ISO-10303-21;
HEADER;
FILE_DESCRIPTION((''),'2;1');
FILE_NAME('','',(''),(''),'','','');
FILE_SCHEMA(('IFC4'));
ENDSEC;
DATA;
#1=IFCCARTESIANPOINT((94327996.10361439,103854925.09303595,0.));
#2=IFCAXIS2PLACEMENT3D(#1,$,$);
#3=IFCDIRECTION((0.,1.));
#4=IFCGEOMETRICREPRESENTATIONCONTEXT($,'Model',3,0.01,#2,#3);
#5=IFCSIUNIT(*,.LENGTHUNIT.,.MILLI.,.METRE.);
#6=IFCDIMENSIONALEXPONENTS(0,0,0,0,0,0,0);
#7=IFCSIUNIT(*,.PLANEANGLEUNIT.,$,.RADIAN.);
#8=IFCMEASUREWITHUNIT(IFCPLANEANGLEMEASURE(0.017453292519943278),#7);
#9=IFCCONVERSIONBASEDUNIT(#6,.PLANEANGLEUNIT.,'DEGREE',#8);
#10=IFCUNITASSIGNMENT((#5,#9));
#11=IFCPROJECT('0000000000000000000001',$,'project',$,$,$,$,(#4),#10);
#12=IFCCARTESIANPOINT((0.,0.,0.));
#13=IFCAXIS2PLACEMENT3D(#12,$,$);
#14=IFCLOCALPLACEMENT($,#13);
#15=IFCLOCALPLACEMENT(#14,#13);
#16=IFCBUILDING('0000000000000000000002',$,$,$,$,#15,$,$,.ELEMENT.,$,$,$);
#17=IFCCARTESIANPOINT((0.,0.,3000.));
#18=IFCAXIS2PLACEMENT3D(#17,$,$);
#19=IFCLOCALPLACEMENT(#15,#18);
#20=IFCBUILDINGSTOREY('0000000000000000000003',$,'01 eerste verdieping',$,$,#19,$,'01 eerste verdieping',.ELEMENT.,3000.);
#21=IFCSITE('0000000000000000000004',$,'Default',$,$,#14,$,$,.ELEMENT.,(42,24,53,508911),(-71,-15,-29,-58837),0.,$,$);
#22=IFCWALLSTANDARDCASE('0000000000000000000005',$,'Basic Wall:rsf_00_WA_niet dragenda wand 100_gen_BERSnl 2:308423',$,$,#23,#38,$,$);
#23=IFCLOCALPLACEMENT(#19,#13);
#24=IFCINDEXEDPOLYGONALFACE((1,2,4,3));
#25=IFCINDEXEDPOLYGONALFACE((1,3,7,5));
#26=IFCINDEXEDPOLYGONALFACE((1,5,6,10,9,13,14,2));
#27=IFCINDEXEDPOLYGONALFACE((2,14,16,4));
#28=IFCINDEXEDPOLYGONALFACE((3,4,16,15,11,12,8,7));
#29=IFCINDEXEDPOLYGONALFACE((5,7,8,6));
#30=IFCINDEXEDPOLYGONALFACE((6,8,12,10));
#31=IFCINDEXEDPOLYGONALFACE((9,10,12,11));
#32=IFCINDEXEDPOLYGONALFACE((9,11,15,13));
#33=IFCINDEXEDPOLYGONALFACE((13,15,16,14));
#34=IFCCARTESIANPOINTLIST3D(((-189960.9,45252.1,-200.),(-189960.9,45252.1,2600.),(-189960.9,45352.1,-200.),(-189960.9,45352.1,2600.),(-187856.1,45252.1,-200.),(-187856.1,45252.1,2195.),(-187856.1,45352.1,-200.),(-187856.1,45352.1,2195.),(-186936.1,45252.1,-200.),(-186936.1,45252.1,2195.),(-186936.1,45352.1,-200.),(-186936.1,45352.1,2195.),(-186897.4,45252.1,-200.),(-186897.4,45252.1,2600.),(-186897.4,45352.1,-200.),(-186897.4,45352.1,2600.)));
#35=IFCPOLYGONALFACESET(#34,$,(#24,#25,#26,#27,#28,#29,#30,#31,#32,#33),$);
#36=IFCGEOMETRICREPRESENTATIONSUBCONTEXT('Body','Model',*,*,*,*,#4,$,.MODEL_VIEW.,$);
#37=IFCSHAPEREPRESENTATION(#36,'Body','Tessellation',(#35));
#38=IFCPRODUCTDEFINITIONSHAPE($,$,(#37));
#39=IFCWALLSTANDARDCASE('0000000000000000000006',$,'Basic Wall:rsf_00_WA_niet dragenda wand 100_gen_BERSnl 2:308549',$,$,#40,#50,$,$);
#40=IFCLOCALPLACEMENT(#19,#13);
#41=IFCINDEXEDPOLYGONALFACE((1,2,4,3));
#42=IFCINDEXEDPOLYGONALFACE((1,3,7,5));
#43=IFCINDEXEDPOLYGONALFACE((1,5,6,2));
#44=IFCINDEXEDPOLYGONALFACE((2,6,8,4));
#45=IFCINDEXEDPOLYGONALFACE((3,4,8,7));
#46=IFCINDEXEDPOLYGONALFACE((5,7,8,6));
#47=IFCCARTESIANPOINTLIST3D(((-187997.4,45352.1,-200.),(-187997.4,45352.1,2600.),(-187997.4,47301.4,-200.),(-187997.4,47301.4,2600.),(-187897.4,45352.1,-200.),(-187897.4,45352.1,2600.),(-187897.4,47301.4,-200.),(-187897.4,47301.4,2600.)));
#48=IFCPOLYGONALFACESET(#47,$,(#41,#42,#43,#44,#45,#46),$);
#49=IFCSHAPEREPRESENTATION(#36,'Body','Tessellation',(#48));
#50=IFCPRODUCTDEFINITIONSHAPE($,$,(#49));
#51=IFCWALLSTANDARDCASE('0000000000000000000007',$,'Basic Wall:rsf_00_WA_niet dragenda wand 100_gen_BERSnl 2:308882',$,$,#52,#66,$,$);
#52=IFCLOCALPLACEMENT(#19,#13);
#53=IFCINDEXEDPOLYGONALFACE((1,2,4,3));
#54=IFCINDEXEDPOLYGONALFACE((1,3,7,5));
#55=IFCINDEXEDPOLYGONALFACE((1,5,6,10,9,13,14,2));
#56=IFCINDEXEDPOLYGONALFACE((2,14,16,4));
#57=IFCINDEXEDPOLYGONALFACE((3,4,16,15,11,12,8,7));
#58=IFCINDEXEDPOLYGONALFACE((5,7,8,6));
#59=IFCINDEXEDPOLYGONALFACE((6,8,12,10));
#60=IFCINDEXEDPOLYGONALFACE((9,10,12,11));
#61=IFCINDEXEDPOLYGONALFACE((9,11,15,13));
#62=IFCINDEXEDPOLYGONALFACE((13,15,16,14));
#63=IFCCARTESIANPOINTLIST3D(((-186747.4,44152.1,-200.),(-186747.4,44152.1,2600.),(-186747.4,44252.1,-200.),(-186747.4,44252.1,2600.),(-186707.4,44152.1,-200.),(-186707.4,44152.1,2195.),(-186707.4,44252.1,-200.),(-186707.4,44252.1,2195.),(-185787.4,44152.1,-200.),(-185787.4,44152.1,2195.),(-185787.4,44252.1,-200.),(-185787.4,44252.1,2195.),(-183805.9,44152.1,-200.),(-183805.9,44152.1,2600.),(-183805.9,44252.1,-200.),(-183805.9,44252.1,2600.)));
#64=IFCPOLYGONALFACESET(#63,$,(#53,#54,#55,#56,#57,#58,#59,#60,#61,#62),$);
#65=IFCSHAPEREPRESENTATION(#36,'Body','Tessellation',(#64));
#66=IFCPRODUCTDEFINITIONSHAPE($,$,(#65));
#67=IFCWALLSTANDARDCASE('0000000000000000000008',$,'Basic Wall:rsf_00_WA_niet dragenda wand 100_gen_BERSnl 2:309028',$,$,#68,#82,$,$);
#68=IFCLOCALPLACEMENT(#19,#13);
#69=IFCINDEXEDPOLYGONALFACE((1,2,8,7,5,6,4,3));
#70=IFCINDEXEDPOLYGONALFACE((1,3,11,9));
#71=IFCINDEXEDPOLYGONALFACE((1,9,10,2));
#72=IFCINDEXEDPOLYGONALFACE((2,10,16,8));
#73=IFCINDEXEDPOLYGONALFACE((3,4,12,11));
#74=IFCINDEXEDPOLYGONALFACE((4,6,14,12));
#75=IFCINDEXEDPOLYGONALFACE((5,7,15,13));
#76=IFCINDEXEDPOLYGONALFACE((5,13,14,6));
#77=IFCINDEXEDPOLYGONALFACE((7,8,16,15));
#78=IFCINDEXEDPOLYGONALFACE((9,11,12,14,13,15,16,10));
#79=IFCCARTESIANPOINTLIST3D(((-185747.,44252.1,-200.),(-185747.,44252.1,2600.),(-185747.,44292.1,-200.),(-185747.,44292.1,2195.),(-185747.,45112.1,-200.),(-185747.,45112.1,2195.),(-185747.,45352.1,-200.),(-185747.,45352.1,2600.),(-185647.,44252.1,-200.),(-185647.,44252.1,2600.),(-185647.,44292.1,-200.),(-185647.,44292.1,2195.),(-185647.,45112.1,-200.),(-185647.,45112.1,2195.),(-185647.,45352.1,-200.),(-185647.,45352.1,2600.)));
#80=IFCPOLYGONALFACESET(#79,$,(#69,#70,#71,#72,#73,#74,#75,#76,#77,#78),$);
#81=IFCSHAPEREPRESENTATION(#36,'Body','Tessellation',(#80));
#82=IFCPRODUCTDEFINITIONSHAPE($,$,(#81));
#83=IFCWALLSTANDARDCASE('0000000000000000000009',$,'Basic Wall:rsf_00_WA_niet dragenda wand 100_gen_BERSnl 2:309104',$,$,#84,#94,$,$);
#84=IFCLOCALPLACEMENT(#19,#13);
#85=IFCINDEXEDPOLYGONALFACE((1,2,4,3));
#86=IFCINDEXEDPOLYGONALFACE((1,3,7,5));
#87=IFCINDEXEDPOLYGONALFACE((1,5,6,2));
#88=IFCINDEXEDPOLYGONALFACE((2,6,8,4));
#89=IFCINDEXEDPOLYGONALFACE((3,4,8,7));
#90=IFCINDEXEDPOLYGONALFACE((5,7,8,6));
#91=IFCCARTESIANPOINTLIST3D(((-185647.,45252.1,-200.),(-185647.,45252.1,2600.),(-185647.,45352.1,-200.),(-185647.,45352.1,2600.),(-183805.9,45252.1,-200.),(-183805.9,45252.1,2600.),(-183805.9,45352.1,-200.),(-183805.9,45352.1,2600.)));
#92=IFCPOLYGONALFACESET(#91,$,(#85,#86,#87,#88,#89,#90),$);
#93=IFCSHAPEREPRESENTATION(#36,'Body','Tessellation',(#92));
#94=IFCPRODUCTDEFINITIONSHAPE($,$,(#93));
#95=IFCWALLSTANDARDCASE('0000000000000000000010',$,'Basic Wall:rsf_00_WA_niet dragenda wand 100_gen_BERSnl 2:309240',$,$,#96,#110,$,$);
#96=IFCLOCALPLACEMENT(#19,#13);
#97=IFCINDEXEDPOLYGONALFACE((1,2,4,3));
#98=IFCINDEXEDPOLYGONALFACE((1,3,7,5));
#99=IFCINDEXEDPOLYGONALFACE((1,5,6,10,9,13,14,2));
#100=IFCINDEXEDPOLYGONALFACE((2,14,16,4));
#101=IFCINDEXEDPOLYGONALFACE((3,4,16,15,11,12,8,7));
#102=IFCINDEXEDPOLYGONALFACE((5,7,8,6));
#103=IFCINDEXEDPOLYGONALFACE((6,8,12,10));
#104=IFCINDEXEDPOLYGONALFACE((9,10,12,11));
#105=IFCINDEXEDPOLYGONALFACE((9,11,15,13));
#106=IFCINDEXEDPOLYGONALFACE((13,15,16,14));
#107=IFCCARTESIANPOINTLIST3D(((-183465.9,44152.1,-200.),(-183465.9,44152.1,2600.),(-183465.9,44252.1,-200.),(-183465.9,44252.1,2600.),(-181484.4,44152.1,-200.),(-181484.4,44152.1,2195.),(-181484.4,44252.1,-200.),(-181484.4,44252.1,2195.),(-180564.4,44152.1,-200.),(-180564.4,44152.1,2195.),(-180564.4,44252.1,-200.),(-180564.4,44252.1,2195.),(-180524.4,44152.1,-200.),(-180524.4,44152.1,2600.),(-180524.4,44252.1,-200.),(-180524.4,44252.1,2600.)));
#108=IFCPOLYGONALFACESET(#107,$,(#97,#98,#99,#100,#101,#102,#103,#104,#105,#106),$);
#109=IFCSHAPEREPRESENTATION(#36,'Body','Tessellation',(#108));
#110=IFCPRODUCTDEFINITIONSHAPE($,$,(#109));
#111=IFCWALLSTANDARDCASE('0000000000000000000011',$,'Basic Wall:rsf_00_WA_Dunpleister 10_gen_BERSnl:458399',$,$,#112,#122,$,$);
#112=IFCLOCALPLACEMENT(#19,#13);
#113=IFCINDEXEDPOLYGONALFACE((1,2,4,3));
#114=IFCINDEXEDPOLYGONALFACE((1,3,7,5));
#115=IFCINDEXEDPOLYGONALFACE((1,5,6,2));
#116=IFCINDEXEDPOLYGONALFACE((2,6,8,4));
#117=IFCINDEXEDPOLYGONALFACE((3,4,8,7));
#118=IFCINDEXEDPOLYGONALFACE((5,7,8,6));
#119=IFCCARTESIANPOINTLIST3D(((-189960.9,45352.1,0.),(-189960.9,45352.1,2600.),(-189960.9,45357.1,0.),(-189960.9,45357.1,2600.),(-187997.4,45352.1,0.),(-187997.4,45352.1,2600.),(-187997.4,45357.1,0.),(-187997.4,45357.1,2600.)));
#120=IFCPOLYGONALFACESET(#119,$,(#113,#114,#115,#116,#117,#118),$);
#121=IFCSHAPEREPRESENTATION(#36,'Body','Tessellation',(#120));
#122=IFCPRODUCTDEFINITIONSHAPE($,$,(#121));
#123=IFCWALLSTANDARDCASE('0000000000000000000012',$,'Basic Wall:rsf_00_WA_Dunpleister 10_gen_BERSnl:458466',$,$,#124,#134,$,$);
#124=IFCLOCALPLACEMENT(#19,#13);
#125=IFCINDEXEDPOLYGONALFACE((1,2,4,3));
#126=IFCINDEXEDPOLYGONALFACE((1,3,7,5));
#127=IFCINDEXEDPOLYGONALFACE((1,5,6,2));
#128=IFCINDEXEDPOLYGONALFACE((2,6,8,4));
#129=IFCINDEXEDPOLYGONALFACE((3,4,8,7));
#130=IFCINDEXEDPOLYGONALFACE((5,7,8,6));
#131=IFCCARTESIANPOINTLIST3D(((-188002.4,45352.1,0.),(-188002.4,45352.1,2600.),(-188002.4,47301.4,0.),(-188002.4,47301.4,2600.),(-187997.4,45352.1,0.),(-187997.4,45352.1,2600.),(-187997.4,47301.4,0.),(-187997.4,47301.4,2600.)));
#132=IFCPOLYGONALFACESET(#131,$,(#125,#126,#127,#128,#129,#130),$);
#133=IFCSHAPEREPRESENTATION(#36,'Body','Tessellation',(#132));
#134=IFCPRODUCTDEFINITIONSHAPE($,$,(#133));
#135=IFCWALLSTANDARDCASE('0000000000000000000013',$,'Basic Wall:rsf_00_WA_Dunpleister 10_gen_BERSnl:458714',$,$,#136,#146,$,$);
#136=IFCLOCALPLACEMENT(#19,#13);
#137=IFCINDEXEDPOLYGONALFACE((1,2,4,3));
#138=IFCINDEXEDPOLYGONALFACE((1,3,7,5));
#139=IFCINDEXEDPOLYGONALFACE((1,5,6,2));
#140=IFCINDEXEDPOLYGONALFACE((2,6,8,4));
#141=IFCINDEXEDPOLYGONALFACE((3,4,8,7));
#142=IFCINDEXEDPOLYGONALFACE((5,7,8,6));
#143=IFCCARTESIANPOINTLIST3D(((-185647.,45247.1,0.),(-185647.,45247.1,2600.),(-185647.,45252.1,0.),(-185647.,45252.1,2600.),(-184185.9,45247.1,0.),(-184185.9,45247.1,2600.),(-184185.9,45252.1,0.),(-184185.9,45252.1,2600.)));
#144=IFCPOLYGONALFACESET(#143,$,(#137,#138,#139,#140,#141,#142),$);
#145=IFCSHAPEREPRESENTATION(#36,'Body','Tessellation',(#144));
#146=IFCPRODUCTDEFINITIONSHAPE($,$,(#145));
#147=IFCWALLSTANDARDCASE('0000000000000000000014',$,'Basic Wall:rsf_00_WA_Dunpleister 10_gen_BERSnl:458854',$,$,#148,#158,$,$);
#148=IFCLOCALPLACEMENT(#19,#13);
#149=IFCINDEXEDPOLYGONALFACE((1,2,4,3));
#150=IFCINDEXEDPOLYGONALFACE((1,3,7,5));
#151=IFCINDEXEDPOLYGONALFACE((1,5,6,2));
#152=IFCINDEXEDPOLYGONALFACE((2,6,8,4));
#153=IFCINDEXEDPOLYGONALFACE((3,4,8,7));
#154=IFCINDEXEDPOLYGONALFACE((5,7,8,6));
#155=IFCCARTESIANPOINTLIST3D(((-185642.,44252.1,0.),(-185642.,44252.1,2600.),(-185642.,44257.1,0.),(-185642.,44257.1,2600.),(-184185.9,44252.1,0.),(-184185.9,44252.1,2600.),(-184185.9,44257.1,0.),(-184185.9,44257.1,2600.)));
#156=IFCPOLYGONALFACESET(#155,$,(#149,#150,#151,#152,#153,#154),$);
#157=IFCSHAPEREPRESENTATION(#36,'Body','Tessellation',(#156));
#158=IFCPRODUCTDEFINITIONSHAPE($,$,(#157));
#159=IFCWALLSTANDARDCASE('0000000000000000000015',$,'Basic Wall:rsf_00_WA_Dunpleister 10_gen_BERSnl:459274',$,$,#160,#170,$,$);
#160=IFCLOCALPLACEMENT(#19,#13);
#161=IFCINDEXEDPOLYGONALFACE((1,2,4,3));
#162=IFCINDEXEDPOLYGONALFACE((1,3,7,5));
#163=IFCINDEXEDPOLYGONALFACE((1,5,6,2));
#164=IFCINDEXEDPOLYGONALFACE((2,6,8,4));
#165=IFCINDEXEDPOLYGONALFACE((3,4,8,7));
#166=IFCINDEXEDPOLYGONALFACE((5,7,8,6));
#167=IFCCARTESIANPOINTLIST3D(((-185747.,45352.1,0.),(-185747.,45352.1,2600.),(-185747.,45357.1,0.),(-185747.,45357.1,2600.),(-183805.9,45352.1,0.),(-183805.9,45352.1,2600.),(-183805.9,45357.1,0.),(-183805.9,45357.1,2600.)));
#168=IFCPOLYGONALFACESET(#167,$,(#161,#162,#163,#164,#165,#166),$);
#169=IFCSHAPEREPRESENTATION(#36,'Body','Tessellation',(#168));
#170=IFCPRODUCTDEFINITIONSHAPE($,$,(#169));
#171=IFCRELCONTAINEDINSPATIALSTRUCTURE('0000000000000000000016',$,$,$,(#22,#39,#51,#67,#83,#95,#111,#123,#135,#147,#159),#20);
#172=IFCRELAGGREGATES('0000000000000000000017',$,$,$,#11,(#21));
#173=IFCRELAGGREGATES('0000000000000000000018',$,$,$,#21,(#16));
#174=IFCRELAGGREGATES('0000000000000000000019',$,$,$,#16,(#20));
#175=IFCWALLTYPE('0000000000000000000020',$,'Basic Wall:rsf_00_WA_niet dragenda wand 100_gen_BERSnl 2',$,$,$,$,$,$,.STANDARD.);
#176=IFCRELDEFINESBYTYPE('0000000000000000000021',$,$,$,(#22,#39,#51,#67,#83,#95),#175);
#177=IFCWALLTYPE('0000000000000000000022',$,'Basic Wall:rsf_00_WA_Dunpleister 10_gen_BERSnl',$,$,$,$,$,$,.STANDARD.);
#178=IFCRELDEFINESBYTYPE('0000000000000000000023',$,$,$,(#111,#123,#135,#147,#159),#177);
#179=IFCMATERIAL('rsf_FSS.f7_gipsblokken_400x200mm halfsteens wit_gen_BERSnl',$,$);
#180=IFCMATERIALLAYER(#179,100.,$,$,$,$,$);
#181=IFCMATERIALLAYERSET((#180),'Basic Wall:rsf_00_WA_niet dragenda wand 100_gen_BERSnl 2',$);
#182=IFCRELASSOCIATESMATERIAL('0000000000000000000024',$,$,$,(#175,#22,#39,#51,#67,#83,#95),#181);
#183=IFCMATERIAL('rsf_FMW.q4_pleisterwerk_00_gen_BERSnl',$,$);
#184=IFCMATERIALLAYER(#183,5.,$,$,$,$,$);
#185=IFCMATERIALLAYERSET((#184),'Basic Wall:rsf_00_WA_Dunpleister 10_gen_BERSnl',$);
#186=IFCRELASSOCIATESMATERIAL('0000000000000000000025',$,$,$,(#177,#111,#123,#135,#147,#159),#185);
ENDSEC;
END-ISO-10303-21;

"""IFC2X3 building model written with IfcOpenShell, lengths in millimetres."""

from ifc_helpers import new_model, entity, si_unit, converted_unit, direction, frame, frame_2d, origin, place, context, subcontext, project, spatial, rectangle, extrude, material, layer, layer_set, layer_usage, type_object, element, save


model = new_model("IFC2X3")

# Units and contexts
model_context = context("Model", 3, precision=0.01, world=frame((94327996.10361439, 103854925.09303595, 0.0)), true_north=direction((0.0, 1.0)))
body_context = subcontext(model_context, "Body", "Model", "MODEL_VIEW")
ifc_project = project(units=[si_unit("LENGTHUNIT", "METRE", prefix="MILLI"), converted_unit("PLANEANGLEUNIT", "DEGREE", entity("IfcPlaneAngleMeasure", 0.017453292519943278), si_unit("PLANEANGLEUNIT", "RADIAN"), dimensions=[0, 0, 0, 0, 0, 0, 0])], contexts=[model_context])

# Site, building, storey
site_placement = place(None, origin())
site = spatial("IfcSite", under=ifc_project, at=site_placement, Name="Default", CompositionType="ELEMENT", RefLatitude=(42, 24, 53, 508911), RefLongitude=(-71, -15, -29, -58837), RefElevation=0.0)
building_placement = place(site_placement, origin())
building = spatial("IfcBuilding", under=site, at=building_placement, CompositionType="ELEMENT")
storey_placement = place(building_placement, frame((0.0, 0.0, 3000.0)))
storey = spatial("IfcBuildingStorey", under=building, at=storey_placement, Name="01 eerste verdieping", LongName="01 eerste verdieping", CompositionType="ELEMENT", Elevation=3000.0)

# Wall, opening
ifc_material_1 = material(Name="rsf_FSS.f7_gipsblokken_400x200mm halfsteens wit_gen_BERSnl")
ifc_layer_1 = layer(ifc_material_1, 100.0)
ifc_layer_set_1 = layer_set([ifc_layer_1], Name="Basic Wall:rsf_00_WA_niet dragenda wand 100_gen_BERSnl 2")
ifc_layer_usage_1 = layer_usage(ifc_layer_set_1, "AXIS2", "NEGATIVE", 50.0)
wall_type_1 = type_object("IfcWallType", Name="Basic Wall:rsf_00_WA_niet dragenda wand 100_gen_BERSnl 2", PredefinedType="STANDARD", material=ifc_layer_set_1)
wall_1_placement = place(storey_placement, frame((-189960.9, 45302.1, -200.0)))
wall_1 = element("IfcWallStandardCase", 1, at=wall_1_placement, inside=storey, type_object=wall_type_1, material=ifc_layer_usage_1, Name="Basic Wall:rsf_00_WA_niet dragenda wand 100_gen_BERSnl 2:308423", context=body_context, shape_type="SweptSolid", body=[
    extrude(rectangle(XDim=3063.5, YDim=100.0, at=frame_2d((1531.7, 0.0), x_axis=(1.0, 0.0))), origin(), (0.0, 0.0, 1.0), 2800.0),
])
opening_1_placement = place(wall_1_placement, frame((2104.7, -50.0, 0.0)))
element("IfcOpeningElement", 2, at=opening_1_placement, cuts=wall_1, ObjectType="Opening", context=body_context, shape_type="SweptSolid", body=[
    extrude(rectangle(XDim=2395.0, YDim=920.0, at=frame_2d((1197.5, 460.0), x_axis=(-1.0, 0.0))), frame((0.0, 0.0, 0.0), z_axis=(0.0, 1.0, 0.0), x_axis=(0.0, 0.0, 1.0)), (0.0, 0.0, 1.0), 100.0),
])

# Wall
ifc_layer_usage_2 = layer_usage(ifc_layer_set_1, "AXIS2", "NEGATIVE", 50.0)
wall_2_placement = place(storey_placement, frame((-187947.4, 45352.1, -200.0), z_axis=(0.0, 0.0, 1.0), x_axis=(0.0, 1.0, 0.0)))
element("IfcWallStandardCase", 3, at=wall_2_placement, inside=storey, type_object=wall_type_1, material=ifc_layer_usage_2, Name="Basic Wall:rsf_00_WA_niet dragenda wand 100_gen_BERSnl 2:308549", context=body_context, shape_type="SweptSolid", body=[
    extrude(rectangle(XDim=1949.4, YDim=100.0, at=frame_2d((974.7, 0.0), x_axis=(-1.0, 0.0))), origin(), (0.0, 0.0, 1.0), 2800.0),
])

# Walls, openings
ifc_layer_usage_3 = layer_usage(ifc_layer_set_1, "AXIS2", "POSITIVE", -50.0)
wall_3_placement = place(storey_placement, frame((-183805.9, 44202.1, -200.0), z_axis=(0.0, 0.0, 1.0), x_axis=(-1.0, 0.0, 0.0)))
wall_3 = element("IfcWallStandardCase", 4, at=wall_3_placement, inside=storey, type_object=wall_type_1, material=ifc_layer_usage_3, Name="Basic Wall:rsf_00_WA_niet dragenda wand 100_gen_BERSnl 2:308882", context=body_context, shape_type="SweptSolid", body=[
    extrude(rectangle(XDim=2941.5, YDim=100.0, at=frame_2d((1470.8, 0.0), x_axis=(1.0, 0.0))), origin(), (0.0, 0.0, 1.0), 2800.0),
])
opening_2_placement = place(wall_3_placement, frame((1981.5, -50.0, 0.0)))
element("IfcOpeningElement", 5, at=opening_2_placement, cuts=wall_3, ObjectType="Opening", context=body_context, shape_type="SweptSolid", body=[
    extrude(rectangle(XDim=2395.0, YDim=920.0, at=frame_2d((1197.5, 460.0), x_axis=(-1.0, 0.0))), frame((0.0, 0.0, 0.0), z_axis=(0.0, 1.0, 0.0), x_axis=(0.0, 0.0, 1.0)), (0.0, 0.0, 1.0), 100.0),
])
ifc_layer_usage_4 = layer_usage(ifc_layer_set_1, "AXIS2", "NEGATIVE", 50.0)
wall_4_placement = place(storey_placement, frame((-185697.0, 44252.1, -200.0), z_axis=(0.0, 0.0, 1.0), x_axis=(0.0, 1.0, 0.0)))
wall_4 = element("IfcWallStandardCase", 6, at=wall_4_placement, inside=storey, type_object=wall_type_1, material=ifc_layer_usage_4, Name="Basic Wall:rsf_00_WA_niet dragenda wand 100_gen_BERSnl 2:309028", context=body_context, shape_type="SweptSolid", body=[
    extrude(rectangle(XDim=1100.0, YDim=100.0, at=frame_2d((550.0, 0.0), x_axis=(1.0, 0.0))), origin(), (0.0, 0.0, 1.0), 2800.0),
])
opening_3_placement = place(wall_4_placement, frame((40.0, -50.0, 0.0)))
element("IfcOpeningElement", 7, at=opening_3_placement, cuts=wall_4, ObjectType="Opening", context=body_context, shape_type="SweptSolid", body=[
    extrude(rectangle(XDim=2395.0, YDim=820.0, at=frame_2d((1197.5, 410.0), x_axis=(-1.0, 0.0))), frame((0.0, 0.0, 0.0), z_axis=(0.0, 1.0, 0.0), x_axis=(0.0, 0.0, 1.0)), (0.0, 0.0, 1.0), 100.0),
])

# Wall
ifc_layer_usage_5 = layer_usage(ifc_layer_set_1, "AXIS2", "NEGATIVE", 50.0)
wall_5_placement = place(storey_placement, frame((-185647.0, 45302.1, -200.0)))
element("IfcWallStandardCase", 8, at=wall_5_placement, inside=storey, type_object=wall_type_1, material=ifc_layer_usage_5, Name="Basic Wall:rsf_00_WA_niet dragenda wand 100_gen_BERSnl 2:309104", context=body_context, shape_type="SweptSolid", body=[
    extrude(rectangle(XDim=1841.2, YDim=100.0, at=frame_2d((920.6, 0.0), x_axis=(-1.0, 0.0))), origin(), (0.0, 0.0, 1.0), 2800.0),
])

# Wall, opening
ifc_layer_usage_6 = layer_usage(ifc_layer_set_1, "AXIS2", "NEGATIVE", 50.0)
wall_6_placement = place(storey_placement, frame((-183465.9, 44202.1, -200.0)))
wall_6 = element("IfcWallStandardCase", 9, at=wall_6_placement, inside=storey, type_object=wall_type_1, material=ifc_layer_usage_6, Name="Basic Wall:rsf_00_WA_niet dragenda wand 100_gen_BERSnl 2:309240", context=body_context, shape_type="SweptSolid", body=[
    extrude(rectangle(XDim=2941.5, YDim=100.0, at=frame_2d((1470.8, 0.0), x_axis=(1.0, 0.0))), origin(), (0.0, 0.0, 1.0), 2800.0),
])
opening_4_placement = place(wall_6_placement, frame((2901.5, 50.0, 0.0)))
element("IfcOpeningElement", 10, at=opening_4_placement, cuts=wall_6, ObjectType="Opening", context=body_context, shape_type="SweptSolid", body=[
    extrude(rectangle(XDim=2395.0, YDim=920.0, at=frame_2d((1197.5, 460.0), x_axis=(-1.0, 0.0))), frame((0.0, 0.0, 0.0), z_axis=(0.0, -1.0, 0.0), x_axis=(0.0, 0.0, 1.0)), (0.0, 0.0, 1.0), 100.0),
])
ifc_material_2 = material(Name="rsf_FMW.q4_pleisterwerk_00_gen_BERSnl")
ifc_layer_2 = layer(ifc_material_2, 5.0)
ifc_layer_set_2 = layer_set([ifc_layer_2], Name="Basic Wall:rsf_00_WA_Dunpleister 10_gen_BERSnl")
wall_type_2 = type_object("IfcWallType", Name="Basic Wall:rsf_00_WA_Dunpleister 10_gen_BERSnl", PredefinedType="STANDARD", material=ifc_layer_set_2)

# Walls
ifc_layer_usage_7 = layer_usage(ifc_layer_set_2, "AXIS2", "NEGATIVE", 2.5)
wall_7_placement = place(storey_placement, frame((-189960.9, 45354.6, 0.0)))
element("IfcWallStandardCase", 11, at=wall_7_placement, inside=storey, type_object=wall_type_2, material=ifc_layer_usage_7, Name="Basic Wall:rsf_00_WA_Dunpleister 10_gen_BERSnl:458399", context=body_context, shape_type="SweptSolid", body=[
    extrude(rectangle(XDim=1963.5, YDim=5.0, at=frame_2d((981.7, 0.0), x_axis=(-1.0, 0.0))), origin(), (0.0, 0.0, 1.0), 2600.0),
])
ifc_layer_usage_8 = layer_usage(ifc_layer_set_2, "AXIS2", "NEGATIVE", 2.5)
wall_8_placement = place(storey_placement, frame((-187999.9, 45352.1, 0.0), z_axis=(0.0, 0.0, 1.0), x_axis=(0.0, 1.0, 0.0)))
element("IfcWallStandardCase", 12, at=wall_8_placement, inside=storey, type_object=wall_type_2, material=ifc_layer_usage_8, Name="Basic Wall:rsf_00_WA_Dunpleister 10_gen_BERSnl:458466", context=body_context, shape_type="SweptSolid", body=[
    extrude(rectangle(XDim=1949.4, YDim=5.0, at=frame_2d((974.7, 0.0), x_axis=(-1.0, 0.0))), origin(), (0.0, 0.0, 1.0), 2600.0),
])
ifc_layer_usage_9 = layer_usage(ifc_layer_set_2, "AXIS2", "NEGATIVE", 2.5)
wall_9_placement = place(storey_placement, frame((-184185.9, 45249.6, 0.0), z_axis=(0.0, 0.0, 1.0), x_axis=(-1.0, 0.0, 0.0)))
element("IfcWallStandardCase", 13, at=wall_9_placement, inside=storey, type_object=wall_type_2, material=ifc_layer_usage_9, Name="Basic Wall:rsf_00_WA_Dunpleister 10_gen_BERSnl:458714", context=body_context, shape_type="SweptSolid", body=[
    extrude(rectangle(XDim=1461.2, YDim=5.0, at=frame_2d((730.6, 0.0), x_axis=(-1.0, 0.0))), origin(), (0.0, 0.0, 1.0), 2600.0),
])

# Wall
ifc_layer_usage_10 = layer_usage(ifc_layer_set_2, "AXIS2", "NEGATIVE", 2.5)
wall_10_placement = place(storey_placement, frame((-185642.0, 44254.6, 0.0)))
element("IfcWallStandardCase", 14, at=wall_10_placement, inside=storey, type_object=wall_type_2, material=ifc_layer_usage_10, Name="Basic Wall:rsf_00_WA_Dunpleister 10_gen_BERSnl:458854", context=body_context, shape_type="SweptSolid", body=[
    extrude(rectangle(XDim=1456.2, YDim=5.0, at=frame_2d((728.1, 0.0), x_axis=(-1.0, 0.0))), origin(), (0.0, 0.0, 1.0), 2600.0),
])

# Wall
ifc_layer_usage_11 = layer_usage(ifc_layer_set_2, "AXIS2", "NEGATIVE", 2.5)
wall_11_placement = place(storey_placement, frame((-185747.0, 45354.6, 0.0)))
element("IfcWallStandardCase", 15, at=wall_11_placement, inside=storey, type_object=wall_type_2, material=ifc_layer_usage_11, Name="Basic Wall:rsf_00_WA_Dunpleister 10_gen_BERSnl:459274", context=body_context, shape_type="SweptSolid", body=[
    extrude(rectangle(XDim=1941.2, YDim=5.0, at=frame_2d((970.6, 0.0), x_axis=(-1.0, 0.0))), origin(), (0.0, 0.0, 1.0), 2600.0),
])

save(model, "model.ifc")
